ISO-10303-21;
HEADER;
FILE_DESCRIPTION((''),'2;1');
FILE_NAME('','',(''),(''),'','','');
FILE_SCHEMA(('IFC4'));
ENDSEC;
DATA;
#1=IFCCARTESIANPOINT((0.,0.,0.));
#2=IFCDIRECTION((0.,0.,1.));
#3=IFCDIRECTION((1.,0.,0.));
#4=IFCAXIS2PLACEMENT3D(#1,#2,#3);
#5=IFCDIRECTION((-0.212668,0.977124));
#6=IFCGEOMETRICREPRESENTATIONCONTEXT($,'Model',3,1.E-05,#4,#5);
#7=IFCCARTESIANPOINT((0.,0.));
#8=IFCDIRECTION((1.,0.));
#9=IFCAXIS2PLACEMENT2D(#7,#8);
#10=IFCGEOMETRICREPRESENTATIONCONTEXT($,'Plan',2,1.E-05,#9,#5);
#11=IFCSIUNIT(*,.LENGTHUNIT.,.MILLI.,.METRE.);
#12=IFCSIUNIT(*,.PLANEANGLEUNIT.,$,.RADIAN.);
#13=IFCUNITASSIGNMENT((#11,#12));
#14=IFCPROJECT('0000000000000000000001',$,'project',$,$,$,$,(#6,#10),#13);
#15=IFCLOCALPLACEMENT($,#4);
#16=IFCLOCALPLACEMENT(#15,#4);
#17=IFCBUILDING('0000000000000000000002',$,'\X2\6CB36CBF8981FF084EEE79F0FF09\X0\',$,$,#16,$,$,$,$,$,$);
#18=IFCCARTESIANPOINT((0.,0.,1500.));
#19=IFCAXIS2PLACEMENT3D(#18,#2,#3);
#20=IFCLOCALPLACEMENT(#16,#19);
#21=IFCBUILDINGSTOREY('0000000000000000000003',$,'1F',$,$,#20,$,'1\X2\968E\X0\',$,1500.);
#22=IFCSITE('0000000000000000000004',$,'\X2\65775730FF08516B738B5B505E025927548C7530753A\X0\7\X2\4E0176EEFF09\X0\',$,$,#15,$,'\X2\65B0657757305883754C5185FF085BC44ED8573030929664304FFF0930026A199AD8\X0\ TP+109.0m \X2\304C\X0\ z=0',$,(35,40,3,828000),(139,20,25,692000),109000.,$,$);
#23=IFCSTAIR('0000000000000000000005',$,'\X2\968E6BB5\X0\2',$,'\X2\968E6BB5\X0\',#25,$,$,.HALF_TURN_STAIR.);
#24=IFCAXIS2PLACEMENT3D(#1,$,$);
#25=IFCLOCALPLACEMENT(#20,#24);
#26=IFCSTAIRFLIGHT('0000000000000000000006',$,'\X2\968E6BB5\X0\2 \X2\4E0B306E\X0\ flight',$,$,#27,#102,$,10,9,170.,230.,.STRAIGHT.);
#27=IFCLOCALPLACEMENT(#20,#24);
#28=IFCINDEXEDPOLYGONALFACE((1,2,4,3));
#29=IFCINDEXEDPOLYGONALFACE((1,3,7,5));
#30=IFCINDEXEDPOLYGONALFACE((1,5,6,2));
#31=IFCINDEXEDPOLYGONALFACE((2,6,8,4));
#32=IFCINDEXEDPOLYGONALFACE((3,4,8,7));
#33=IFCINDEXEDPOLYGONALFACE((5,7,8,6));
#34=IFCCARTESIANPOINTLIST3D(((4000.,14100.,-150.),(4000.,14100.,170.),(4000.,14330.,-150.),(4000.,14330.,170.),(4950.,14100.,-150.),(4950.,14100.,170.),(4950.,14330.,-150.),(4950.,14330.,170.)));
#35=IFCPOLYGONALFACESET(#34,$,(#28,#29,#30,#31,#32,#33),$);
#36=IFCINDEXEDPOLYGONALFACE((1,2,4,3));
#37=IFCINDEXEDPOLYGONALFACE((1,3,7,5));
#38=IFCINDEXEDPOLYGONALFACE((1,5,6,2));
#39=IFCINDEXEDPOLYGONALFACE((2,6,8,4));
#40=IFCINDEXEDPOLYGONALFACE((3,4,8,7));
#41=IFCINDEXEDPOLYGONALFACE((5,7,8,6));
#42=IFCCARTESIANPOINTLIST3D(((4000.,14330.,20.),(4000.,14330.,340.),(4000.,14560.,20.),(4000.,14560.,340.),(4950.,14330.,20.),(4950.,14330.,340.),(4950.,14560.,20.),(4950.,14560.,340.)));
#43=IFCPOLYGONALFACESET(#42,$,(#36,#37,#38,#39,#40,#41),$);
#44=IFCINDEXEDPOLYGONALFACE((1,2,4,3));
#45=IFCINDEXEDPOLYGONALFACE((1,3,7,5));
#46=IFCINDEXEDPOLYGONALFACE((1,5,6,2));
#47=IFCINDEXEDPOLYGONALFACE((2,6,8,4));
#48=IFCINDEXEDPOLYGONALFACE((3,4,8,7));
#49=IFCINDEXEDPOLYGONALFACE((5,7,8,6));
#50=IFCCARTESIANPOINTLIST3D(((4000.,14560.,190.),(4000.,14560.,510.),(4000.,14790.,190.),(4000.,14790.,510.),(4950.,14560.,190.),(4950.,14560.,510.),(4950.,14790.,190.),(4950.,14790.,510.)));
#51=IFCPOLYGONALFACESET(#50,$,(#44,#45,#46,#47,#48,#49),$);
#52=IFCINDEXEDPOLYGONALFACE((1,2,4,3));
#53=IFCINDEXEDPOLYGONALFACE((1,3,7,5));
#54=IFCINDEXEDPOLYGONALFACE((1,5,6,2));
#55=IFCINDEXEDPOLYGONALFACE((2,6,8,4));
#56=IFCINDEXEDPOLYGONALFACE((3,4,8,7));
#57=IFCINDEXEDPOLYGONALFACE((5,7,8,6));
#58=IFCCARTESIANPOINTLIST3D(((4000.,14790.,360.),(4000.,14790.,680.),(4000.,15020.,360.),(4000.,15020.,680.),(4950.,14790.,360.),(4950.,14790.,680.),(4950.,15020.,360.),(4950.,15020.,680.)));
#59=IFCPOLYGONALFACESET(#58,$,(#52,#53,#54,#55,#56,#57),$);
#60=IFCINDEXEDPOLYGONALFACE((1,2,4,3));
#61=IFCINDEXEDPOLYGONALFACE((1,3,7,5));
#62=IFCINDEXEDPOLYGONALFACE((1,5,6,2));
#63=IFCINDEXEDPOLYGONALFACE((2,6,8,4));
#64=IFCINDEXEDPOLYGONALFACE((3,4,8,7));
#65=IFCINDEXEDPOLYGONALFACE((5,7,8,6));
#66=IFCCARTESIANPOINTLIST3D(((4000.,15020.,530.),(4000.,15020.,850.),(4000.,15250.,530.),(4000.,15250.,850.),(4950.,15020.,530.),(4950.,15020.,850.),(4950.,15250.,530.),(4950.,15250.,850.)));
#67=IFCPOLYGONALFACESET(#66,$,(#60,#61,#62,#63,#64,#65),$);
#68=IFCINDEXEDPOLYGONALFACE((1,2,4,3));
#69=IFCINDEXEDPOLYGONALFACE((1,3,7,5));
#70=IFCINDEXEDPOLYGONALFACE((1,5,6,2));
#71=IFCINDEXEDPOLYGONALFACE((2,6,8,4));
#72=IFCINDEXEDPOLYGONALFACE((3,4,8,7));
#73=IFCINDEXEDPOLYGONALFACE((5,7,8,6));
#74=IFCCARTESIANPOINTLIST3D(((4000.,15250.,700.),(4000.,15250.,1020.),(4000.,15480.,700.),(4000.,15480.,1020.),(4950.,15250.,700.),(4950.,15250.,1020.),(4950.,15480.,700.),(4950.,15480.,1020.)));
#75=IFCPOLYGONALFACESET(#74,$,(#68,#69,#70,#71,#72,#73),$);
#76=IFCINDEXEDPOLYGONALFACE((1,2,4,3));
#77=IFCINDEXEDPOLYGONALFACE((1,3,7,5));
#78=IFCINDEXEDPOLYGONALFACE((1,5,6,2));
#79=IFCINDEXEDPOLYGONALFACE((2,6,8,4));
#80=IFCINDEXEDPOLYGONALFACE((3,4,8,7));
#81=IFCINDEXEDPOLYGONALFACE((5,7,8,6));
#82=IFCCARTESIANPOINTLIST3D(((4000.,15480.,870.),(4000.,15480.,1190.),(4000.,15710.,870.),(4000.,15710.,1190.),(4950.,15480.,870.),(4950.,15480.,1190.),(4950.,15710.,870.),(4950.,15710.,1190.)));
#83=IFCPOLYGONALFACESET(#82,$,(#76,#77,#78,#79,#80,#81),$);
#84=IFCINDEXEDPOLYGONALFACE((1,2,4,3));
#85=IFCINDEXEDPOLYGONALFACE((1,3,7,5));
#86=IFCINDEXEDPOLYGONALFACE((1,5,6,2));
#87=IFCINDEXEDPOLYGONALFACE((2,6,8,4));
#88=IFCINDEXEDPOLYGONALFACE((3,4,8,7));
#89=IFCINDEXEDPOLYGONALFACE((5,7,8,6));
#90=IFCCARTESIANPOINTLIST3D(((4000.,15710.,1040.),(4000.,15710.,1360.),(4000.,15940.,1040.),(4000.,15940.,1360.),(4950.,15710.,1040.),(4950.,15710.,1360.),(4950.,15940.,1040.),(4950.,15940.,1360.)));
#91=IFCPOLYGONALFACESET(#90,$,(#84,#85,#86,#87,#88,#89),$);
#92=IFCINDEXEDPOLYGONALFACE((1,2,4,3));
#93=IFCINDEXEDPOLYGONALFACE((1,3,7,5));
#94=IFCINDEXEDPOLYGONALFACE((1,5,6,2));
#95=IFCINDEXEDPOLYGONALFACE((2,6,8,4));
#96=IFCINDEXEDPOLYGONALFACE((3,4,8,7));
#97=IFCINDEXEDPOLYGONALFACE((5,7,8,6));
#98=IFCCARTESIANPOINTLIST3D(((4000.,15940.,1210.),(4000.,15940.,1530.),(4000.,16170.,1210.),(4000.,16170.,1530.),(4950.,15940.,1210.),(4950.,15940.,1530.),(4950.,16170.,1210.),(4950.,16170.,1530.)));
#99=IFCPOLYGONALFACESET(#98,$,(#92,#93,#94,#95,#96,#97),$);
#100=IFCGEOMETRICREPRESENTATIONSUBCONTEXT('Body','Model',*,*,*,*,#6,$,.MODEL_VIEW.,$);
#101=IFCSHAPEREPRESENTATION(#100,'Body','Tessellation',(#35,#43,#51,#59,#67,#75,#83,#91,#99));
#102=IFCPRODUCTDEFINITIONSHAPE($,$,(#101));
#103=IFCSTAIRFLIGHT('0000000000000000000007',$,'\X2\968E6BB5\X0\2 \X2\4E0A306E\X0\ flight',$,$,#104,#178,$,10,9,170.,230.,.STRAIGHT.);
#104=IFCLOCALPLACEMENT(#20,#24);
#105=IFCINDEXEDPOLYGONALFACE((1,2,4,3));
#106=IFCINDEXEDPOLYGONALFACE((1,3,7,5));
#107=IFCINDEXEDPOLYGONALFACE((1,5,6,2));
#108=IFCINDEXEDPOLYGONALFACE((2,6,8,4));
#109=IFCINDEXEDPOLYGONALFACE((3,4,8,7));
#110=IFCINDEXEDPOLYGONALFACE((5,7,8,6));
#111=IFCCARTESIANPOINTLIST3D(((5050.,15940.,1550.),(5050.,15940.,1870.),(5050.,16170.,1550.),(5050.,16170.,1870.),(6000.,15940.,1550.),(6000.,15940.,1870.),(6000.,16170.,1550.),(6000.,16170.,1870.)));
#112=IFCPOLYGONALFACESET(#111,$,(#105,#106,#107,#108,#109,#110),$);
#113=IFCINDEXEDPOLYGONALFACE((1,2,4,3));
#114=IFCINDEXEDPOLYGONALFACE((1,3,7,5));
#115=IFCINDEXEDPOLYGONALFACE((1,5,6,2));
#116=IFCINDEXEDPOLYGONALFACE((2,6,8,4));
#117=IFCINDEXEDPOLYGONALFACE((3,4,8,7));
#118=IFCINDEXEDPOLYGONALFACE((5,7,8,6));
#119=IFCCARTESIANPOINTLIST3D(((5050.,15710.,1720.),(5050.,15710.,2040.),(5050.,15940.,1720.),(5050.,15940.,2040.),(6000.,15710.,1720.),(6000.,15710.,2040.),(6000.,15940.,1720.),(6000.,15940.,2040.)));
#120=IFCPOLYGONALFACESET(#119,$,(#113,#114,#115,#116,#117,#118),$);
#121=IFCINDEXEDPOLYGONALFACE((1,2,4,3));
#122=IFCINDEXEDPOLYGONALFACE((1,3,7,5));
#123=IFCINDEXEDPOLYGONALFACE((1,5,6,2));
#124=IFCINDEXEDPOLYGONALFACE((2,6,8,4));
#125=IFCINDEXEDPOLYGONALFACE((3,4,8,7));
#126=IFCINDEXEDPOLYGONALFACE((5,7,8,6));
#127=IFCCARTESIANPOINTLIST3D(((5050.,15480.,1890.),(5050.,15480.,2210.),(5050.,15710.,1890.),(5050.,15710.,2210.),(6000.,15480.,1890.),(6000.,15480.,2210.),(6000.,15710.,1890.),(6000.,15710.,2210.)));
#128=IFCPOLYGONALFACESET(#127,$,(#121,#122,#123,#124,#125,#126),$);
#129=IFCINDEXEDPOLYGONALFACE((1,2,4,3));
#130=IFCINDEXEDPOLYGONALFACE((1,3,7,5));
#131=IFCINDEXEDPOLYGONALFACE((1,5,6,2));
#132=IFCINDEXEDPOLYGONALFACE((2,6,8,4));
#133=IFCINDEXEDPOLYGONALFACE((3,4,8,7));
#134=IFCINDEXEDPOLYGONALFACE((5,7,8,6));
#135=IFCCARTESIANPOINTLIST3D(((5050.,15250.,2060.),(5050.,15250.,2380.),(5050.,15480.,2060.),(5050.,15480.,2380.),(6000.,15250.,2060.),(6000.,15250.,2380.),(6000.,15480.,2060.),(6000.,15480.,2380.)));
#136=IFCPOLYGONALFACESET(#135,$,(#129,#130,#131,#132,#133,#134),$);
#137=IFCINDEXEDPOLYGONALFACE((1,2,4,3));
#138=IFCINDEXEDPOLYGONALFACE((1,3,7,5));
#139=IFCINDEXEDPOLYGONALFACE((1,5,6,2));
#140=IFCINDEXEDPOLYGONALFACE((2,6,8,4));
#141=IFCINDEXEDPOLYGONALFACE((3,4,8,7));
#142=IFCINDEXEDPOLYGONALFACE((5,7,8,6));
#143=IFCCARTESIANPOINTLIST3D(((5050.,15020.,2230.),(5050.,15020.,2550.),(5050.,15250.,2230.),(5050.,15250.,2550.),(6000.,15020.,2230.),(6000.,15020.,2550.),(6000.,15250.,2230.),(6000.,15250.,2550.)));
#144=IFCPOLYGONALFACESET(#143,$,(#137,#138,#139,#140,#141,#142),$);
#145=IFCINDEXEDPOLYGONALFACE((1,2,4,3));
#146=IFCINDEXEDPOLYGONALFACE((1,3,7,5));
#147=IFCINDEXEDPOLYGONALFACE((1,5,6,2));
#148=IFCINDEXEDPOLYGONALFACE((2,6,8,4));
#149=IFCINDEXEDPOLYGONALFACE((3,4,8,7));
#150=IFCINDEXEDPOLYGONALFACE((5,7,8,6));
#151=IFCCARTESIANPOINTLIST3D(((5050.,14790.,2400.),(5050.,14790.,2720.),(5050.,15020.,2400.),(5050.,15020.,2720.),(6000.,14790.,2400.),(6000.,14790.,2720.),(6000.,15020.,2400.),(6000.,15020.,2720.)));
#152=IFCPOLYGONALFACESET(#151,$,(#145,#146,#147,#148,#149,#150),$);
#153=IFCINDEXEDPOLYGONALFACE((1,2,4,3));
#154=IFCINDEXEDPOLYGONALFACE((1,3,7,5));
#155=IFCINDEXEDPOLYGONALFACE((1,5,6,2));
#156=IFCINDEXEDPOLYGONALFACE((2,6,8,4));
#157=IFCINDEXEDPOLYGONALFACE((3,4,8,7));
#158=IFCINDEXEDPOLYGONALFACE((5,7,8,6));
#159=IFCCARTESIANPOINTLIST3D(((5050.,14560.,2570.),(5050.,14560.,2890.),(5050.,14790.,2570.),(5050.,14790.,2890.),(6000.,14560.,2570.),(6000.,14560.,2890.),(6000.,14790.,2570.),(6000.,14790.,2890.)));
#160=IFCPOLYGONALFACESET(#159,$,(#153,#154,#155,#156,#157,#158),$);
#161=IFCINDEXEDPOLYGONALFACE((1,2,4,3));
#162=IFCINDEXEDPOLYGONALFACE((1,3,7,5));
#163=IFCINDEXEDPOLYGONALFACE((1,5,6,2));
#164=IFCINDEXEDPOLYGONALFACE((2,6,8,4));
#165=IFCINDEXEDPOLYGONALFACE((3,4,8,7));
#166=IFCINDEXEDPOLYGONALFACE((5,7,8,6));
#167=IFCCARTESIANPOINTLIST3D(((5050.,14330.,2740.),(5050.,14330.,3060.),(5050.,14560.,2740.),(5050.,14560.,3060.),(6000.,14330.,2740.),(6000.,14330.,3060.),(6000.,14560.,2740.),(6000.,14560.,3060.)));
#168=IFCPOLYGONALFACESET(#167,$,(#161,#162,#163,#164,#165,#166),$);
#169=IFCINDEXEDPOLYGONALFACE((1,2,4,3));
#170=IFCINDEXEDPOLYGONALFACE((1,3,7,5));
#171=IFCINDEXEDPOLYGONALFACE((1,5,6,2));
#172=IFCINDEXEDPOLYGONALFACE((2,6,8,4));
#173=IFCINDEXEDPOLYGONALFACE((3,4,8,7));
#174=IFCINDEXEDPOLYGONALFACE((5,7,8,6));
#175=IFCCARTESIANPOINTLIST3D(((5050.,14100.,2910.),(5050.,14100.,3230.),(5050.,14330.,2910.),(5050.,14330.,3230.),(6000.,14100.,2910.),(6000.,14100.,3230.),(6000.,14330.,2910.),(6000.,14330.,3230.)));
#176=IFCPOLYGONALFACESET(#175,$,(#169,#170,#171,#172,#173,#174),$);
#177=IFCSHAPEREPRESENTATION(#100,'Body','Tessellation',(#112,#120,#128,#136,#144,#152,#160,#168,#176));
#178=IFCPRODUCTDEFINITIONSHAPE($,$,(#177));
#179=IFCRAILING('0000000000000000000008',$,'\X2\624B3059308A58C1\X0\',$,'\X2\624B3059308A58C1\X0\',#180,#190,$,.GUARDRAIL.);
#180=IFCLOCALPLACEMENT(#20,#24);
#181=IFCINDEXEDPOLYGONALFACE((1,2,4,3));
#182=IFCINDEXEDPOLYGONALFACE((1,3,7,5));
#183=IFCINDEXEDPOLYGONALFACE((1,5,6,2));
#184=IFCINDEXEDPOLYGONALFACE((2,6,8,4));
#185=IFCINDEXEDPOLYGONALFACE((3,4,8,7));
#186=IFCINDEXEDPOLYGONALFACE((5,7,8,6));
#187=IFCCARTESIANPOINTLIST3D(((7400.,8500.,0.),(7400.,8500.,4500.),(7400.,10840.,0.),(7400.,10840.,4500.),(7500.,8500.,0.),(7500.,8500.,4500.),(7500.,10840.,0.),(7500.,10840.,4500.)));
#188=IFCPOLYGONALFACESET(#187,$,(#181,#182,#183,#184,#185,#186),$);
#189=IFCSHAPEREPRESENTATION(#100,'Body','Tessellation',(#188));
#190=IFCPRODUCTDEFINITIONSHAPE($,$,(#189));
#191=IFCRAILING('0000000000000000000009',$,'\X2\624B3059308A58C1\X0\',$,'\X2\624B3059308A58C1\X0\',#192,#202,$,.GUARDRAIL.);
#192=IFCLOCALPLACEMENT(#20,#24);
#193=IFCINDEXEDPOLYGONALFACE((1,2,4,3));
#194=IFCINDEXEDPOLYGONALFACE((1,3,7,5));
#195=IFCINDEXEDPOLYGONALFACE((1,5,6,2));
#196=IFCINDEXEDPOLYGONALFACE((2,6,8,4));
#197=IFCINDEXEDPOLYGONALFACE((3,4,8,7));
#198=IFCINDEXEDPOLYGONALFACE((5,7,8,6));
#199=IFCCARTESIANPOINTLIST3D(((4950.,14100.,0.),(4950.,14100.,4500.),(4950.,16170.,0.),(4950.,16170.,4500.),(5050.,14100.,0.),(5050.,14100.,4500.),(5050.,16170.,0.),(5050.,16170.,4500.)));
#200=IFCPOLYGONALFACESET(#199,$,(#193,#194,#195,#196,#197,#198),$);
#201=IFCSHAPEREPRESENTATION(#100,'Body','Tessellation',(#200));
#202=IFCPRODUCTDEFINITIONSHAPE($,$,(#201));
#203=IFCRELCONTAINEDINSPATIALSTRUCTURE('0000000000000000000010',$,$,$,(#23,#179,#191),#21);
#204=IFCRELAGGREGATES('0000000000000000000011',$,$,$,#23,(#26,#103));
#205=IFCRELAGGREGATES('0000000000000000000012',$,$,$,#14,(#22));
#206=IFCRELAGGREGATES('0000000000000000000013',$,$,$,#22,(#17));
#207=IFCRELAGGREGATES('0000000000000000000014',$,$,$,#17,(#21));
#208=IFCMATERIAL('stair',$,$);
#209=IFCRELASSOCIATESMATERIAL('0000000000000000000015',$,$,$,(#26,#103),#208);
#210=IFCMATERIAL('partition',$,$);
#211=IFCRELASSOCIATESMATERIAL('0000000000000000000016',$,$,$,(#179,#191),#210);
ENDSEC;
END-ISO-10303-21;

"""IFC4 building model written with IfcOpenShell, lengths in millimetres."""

from ifc_helpers import new_model, si_unit, direction, frame, frame_2d, origin, origin_with_axes, origin_2d_with_axis, place, context, subcontext, project, spatial, rectangle, extrude, material, element, aggregate, save


model = new_model("IFC4")

# Units and contexts
model_context = context("Model", 3, precision=1e-05, world=origin_with_axes(), true_north=direction((-0.212668, 0.977124)))
plan_context = context("Plan", 2, precision=1e-05, world=origin_2d_with_axis(), true_north=direction((-0.212668, 0.977124)))
body_context = subcontext(model_context, "Body", "Model", "MODEL_VIEW")
ifc_project = project(units=[si_unit("LENGTHUNIT", "METRE", prefix="MILLI"), si_unit("PLANEANGLEUNIT", "RADIAN")], contexts=[model_context, plan_context])

# Site, building, storey
site_placement = place(None, origin_with_axes())
site = spatial("IfcSite", under=ifc_project, at=site_placement, Name="敷地（八王子市大和田町7丁目）", LongName="新敷地境界内（寄付地を除く）。標高 TP+109.0m が z=0", RefLatitude=(35, 40, 3, 828000), RefLongitude=(139, 20, 25, 692000), RefElevation=109000.0)
building_placement = place(site_placement, origin_with_axes())
building = spatial("IfcBuilding", under=site, at=building_placement, Name="河沿要（仮称）")
storey_placement = place(building_placement, frame((0.0, 0.0, 1500.0), z_axis=(0.0, 0.0, 1.0), x_axis=(1.0, 0.0, 0.0)))
storey = spatial("IfcBuildingStorey", under=building, at=storey_placement, Name="1F", LongName="1階", Elevation=1500.0)

# Stair
ifc_material_1 = material(Name="stair")
stair_1_placement = place(storey_placement, origin_with_axes())
stair_1 = element("IfcStair", 1, at=stair_1_placement, inside=storey, Name="階段2", ObjectType="階段", PredefinedType="HALF_TURN_STAIR")

# Stair flights
stair_flight_1_placement = place(stair_1_placement, origin_with_axes())
stair_flight_1 = element("IfcStairFlight", 2, at=stair_flight_1_placement, material=ifc_material_1, Name="階段2 下の flight", NumberOfRisers=10, NumberOfTreads=9, PredefinedType="STRAIGHT", RiserHeight=170.0, TreadLength=230.0, context=body_context, shape_type="SweptSolid", body=[
    extrude(rectangle(XDim=950.0, YDim=230.0, at=frame_2d((4475.0, 14215.0))), frame((0.0, 0.0, -150.0)), (0.0, 0.0, 1.0), 320.0),
    extrude(rectangle(XDim=950.0, YDim=230.0, at=frame_2d((4475.0, 14445.0))), frame((0.0, 0.0, 20.0)), (0.0, 0.0, 1.0), 320.0),
    extrude(rectangle(XDim=950.0, YDim=230.0, at=frame_2d((4475.0, 14675.0))), frame((0.0, 0.0, 190.0)), (0.0, 0.0, 1.0), 320.0),
    extrude(rectangle(XDim=950.0, YDim=230.0, at=frame_2d((4475.0, 14905.0))), frame((0.0, 0.0, 360.0)), (0.0, 0.0, 1.0), 320.0),
    extrude(rectangle(XDim=950.0, YDim=230.0, at=frame_2d((4475.0, 15135.0))), frame((0.0, 0.0, 530.0)), (0.0, 0.0, 1.0), 320.0),
    extrude(rectangle(XDim=950.0, YDim=230.0, at=frame_2d((4475.0, 15365.0))), frame((0.0, 0.0, 700.0)), (0.0, 0.0, 1.0), 320.0),
    extrude(rectangle(XDim=950.0, YDim=230.0, at=frame_2d((4475.0, 15595.0))), frame((0.0, 0.0, 870.0)), (0.0, 0.0, 1.0), 320.0),
    extrude(rectangle(XDim=950.0, YDim=230.0, at=frame_2d((4475.0, 15825.0))), frame((0.0, 0.0, 1040.0)), (0.0, 0.0, 1.0), 320.0),
    extrude(rectangle(XDim=950.0, YDim=230.0, at=frame_2d((4475.0, 16055.0))), frame((0.0, 0.0, 1210.0)), (0.0, 0.0, 1.0), 320.0),
])
stair_flight_2_placement = place(stair_1_placement, origin_with_axes())
stair_flight_2 = element("IfcStairFlight", 3, at=stair_flight_2_placement, material=ifc_material_1, Name="階段2 上の flight", NumberOfRisers=10, NumberOfTreads=9, PredefinedType="STRAIGHT", RiserHeight=170.0, TreadLength=230.0, context=body_context, shape_type="SweptSolid", body=[
    extrude(rectangle(XDim=950.0, YDim=230.0, at=frame_2d((5525.0, 16055.0))), frame((0.0, 0.0, 1550.0)), (0.0, 0.0, 1.0), 320.0),
    extrude(rectangle(XDim=950.0, YDim=230.0, at=frame_2d((5525.0, 15825.0))), frame((0.0, 0.0, 1720.0)), (0.0, 0.0, 1.0), 320.0),
    extrude(rectangle(XDim=950.0, YDim=230.0, at=frame_2d((5525.0, 15595.0))), frame((0.0, 0.0, 1890.0)), (0.0, 0.0, 1.0), 320.0),
    extrude(rectangle(XDim=950.0, YDim=230.0, at=frame_2d((5525.0, 15365.0))), frame((0.0, 0.0, 2060.0)), (0.0, 0.0, 1.0), 320.0),
    extrude(rectangle(XDim=950.0, YDim=230.0, at=frame_2d((5525.0, 15135.0))), frame((0.0, 0.0, 2230.0)), (0.0, 0.0, 1.0), 320.0),
    extrude(rectangle(XDim=950.0, YDim=230.0, at=frame_2d((5525.0, 14905.0))), frame((0.0, 0.0, 2400.0)), (0.0, 0.0, 1.0), 320.0),
    extrude(rectangle(XDim=950.0, YDim=230.0, at=frame_2d((5525.0, 14675.0))), frame((0.0, 0.0, 2570.0)), (0.0, 0.0, 1.0), 320.0),
    extrude(rectangle(XDim=950.0, YDim=230.0, at=frame_2d((5525.0, 14445.0))), frame((0.0, 0.0, 2740.0)), (0.0, 0.0, 1.0), 320.0),
    extrude(rectangle(XDim=950.0, YDim=230.0, at=frame_2d((5525.0, 14215.0))), frame((0.0, 0.0, 2910.0)), (0.0, 0.0, 1.0), 320.0),
])
aggregate(stair_1, [stair_flight_1, stair_flight_2])

# Railings
ifc_material_2 = material(Name="partition")
railing_1_placement = place(storey_placement, origin_with_axes())
element("IfcRailing", 4, at=railing_1_placement, inside=storey, material=ifc_material_2, Name="手すり壁", ObjectType="手すり壁", PredefinedType="GUARDRAIL", context=body_context, shape_type="SweptSolid", body=[
    extrude(rectangle(XDim=100.0, YDim=2340.0, at=frame_2d((7450.0, 9670.0))), origin(), (0.0, 0.0, 1.0), 4500.0),
])
railing_2_placement = place(storey_placement, origin_with_axes())
element("IfcRailing", 5, at=railing_2_placement, inside=storey, material=ifc_material_2, Name="手すり壁", ObjectType="手すり壁", PredefinedType="GUARDRAIL", context=body_context, shape_type="SweptSolid", body=[
    extrude(rectangle(XDim=100.0, YDim=2070.0, at=frame_2d((5000.0, 15135.0))), origin(), (0.0, 0.0, 1.0), 4500.0),
])

save(model, "model.ifc")
